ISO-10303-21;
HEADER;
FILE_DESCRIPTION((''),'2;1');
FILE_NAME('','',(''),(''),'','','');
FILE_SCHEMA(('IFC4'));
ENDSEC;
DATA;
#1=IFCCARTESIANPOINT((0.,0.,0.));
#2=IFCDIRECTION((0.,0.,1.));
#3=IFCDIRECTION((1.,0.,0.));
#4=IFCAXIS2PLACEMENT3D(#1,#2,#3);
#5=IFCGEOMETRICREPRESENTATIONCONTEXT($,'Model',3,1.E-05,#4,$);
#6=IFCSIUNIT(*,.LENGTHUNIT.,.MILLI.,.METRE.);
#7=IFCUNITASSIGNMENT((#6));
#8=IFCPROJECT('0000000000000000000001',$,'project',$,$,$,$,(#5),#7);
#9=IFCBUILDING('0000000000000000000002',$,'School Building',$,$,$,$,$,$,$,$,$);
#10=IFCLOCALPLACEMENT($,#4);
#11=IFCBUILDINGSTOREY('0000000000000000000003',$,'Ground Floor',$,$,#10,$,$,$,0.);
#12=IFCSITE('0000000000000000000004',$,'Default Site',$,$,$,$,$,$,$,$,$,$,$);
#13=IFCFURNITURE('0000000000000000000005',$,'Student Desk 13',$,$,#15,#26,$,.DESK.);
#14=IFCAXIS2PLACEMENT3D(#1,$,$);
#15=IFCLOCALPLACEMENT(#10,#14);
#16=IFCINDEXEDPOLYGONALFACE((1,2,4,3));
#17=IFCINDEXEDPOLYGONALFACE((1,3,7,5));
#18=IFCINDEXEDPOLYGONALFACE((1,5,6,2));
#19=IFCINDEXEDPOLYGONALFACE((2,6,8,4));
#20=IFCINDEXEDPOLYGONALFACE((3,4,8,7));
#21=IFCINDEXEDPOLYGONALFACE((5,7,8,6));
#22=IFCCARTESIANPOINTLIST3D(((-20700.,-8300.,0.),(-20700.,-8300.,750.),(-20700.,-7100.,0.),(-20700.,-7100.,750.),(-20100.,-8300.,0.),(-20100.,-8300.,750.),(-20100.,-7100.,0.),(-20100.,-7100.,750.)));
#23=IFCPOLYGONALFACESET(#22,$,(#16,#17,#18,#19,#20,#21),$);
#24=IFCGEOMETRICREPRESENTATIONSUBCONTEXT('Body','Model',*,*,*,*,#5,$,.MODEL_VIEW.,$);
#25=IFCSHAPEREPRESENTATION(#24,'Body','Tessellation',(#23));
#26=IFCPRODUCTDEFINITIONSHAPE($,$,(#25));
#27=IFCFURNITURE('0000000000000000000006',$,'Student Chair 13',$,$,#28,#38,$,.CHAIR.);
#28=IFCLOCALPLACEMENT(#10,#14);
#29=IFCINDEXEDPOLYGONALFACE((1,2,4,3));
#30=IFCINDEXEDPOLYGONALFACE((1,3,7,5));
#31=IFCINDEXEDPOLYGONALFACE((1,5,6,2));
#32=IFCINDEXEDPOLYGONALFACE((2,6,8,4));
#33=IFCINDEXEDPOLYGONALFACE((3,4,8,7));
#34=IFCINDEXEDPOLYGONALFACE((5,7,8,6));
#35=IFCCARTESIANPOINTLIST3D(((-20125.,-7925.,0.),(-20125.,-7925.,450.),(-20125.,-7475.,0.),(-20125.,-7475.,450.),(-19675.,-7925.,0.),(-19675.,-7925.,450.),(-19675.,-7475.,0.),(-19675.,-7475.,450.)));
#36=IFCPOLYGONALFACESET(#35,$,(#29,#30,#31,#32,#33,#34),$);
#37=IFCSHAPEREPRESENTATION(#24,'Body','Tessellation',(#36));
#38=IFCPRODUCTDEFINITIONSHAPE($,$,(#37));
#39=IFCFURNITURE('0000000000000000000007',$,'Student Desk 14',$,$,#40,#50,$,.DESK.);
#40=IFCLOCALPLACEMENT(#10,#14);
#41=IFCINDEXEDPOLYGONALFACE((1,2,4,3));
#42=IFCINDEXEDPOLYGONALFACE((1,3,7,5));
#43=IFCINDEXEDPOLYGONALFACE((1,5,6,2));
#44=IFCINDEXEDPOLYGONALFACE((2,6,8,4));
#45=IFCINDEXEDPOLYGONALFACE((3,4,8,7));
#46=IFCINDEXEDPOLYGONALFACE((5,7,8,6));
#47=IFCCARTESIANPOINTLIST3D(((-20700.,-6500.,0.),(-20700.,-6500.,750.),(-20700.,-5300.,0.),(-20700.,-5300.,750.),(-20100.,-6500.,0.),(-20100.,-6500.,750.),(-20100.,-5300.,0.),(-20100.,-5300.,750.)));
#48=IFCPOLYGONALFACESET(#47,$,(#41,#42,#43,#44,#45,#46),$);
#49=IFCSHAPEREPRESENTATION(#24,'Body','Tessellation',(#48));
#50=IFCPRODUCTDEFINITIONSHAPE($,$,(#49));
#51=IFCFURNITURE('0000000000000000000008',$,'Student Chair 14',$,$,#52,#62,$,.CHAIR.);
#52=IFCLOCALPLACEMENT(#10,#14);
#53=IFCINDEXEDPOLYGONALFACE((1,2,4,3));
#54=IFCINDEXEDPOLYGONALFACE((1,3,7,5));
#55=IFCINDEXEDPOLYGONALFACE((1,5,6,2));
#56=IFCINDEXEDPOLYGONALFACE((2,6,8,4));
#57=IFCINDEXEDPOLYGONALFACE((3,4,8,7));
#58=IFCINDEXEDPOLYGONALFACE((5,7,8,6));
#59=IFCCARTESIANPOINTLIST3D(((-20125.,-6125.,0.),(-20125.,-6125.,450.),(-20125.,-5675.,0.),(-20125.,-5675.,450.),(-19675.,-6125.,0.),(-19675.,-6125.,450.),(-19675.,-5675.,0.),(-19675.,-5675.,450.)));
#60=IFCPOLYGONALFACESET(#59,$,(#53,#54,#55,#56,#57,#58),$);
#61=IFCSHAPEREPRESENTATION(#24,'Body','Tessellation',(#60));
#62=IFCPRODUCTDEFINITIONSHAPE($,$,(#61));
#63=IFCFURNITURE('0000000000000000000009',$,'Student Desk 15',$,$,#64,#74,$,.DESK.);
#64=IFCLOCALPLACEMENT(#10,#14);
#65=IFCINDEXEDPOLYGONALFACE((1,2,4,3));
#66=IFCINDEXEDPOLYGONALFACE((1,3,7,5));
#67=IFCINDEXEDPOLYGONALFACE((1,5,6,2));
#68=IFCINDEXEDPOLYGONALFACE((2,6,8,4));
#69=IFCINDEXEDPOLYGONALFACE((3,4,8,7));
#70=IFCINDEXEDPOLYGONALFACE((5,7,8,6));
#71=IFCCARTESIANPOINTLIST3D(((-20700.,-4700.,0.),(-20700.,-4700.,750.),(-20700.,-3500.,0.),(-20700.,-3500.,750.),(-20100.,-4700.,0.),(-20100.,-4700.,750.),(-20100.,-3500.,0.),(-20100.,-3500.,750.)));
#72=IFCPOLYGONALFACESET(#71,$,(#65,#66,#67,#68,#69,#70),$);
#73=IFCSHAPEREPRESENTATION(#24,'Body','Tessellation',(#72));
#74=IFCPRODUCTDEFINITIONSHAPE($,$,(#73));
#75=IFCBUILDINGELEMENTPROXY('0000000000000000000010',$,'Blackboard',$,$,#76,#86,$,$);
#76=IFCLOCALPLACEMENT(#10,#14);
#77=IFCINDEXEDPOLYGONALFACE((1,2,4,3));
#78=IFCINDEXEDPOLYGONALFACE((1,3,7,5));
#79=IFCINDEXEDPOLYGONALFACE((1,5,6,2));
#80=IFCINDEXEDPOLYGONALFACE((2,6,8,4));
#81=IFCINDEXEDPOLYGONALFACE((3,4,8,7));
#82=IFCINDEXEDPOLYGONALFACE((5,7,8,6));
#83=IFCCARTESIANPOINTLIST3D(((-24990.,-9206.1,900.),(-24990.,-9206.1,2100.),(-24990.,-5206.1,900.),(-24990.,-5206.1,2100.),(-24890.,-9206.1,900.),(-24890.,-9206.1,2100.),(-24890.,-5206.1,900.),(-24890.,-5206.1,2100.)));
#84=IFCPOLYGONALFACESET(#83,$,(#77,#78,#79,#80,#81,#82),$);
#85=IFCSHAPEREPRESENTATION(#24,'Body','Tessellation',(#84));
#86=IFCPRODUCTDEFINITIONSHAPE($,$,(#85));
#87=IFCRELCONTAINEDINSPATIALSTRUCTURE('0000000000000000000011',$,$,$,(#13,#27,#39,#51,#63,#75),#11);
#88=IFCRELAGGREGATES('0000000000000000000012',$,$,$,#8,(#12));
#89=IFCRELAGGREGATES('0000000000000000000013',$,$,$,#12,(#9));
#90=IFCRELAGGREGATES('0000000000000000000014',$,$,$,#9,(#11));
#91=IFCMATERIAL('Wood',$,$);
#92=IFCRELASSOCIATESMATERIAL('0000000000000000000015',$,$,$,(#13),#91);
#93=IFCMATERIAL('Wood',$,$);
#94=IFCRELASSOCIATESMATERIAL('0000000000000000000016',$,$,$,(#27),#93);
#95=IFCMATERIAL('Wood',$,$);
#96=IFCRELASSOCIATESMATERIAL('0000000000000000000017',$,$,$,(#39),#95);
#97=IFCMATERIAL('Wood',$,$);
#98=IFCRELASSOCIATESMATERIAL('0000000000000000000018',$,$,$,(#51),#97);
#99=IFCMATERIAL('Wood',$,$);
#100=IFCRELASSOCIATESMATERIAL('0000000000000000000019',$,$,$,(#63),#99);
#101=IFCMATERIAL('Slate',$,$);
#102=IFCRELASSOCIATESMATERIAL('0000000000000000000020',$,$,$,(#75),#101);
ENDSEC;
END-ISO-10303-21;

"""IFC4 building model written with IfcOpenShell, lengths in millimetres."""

from ifc_helpers import new_model, si_unit, frame, origin_with_axes, origin_2d, place, context, subcontext, project, spatial, rectangle, extrude, material, element, save


model = new_model("IFC4")

# Units and contexts
model_context = context("Model", 3, precision=1e-05, world=origin_with_axes())
body_context = subcontext(model_context, "Body", "Model", "MODEL_VIEW")
ifc_project = project(units=[si_unit("LENGTHUNIT", "METRE", prefix="MILLI")], contexts=[model_context])

# Site, building, storey
site = spatial("IfcSite", under=ifc_project, Name="Default Site")
building = spatial("IfcBuilding", under=site, Name="School Building")
storey_placement = place(None, origin_with_axes())
storey = spatial("IfcBuildingStorey", under=building, at=storey_placement, Name="Ground Floor", Elevation=0.0)

# Furniture
ifc_material_1 = material(Name="Wood")
furniture_1_placement = place(storey_placement, frame((-20400.0, -7700.0, 0.0), z_axis=(0.0, 0.0, 1.0), x_axis=(0.0, 1.0, 0.0)))
element("IfcFurniture", 1, at=furniture_1_placement, inside=storey, material=ifc_material_1, Name="Student Desk 13", PredefinedType="DESK", context=body_context, shape_type="SweptSolid", body=[
    extrude(rectangle(XDim=1200.0, YDim=600.0, at=origin_2d()), origin_with_axes(), (0.0, 0.0, 1.0), 750.0),
])
ifc_material_2 = material(Name="Wood")
furniture_2_placement = place(storey_placement, frame((-19900.0, -7700.0, 0.0), z_axis=(0.0, 0.0, 1.0), x_axis=(1.0, 0.0, 0.0)))
element("IfcFurniture", 2, at=furniture_2_placement, inside=storey, material=ifc_material_2, Name="Student Chair 13", PredefinedType="CHAIR", context=body_context, shape_type="SweptSolid", body=[
    extrude(rectangle(XDim=450.0, YDim=450.0, at=origin_2d()), origin_with_axes(), (0.0, 0.0, 1.0), 450.0),
])
ifc_material_3 = material(Name="Wood")
furniture_3_placement = place(storey_placement, frame((-20400.0, -5900.0, 0.0), z_axis=(0.0, 0.0, 1.0), x_axis=(0.0, 1.0, 0.0)))
element("IfcFurniture", 3, at=furniture_3_placement, inside=storey, material=ifc_material_3, Name="Student Desk 14", PredefinedType="DESK", context=body_context, shape_type="SweptSolid", body=[
    extrude(rectangle(XDim=1200.0, YDim=600.0, at=origin_2d()), origin_with_axes(), (0.0, 0.0, 1.0), 750.0),
])
ifc_material_4 = material(Name="Wood")
furniture_4_placement = place(storey_placement, frame((-19900.0, -5900.0, 0.0), z_axis=(0.0, 0.0, 1.0), x_axis=(1.0, 0.0, 0.0)))
element("IfcFurniture", 4, at=furniture_4_placement, inside=storey, material=ifc_material_4, Name="Student Chair 14", PredefinedType="CHAIR", context=body_context, shape_type="SweptSolid", body=[
    extrude(rectangle(XDim=450.0, YDim=450.0, at=origin_2d()), origin_with_axes(), (0.0, 0.0, 1.0), 450.0),
])
ifc_material_5 = material(Name="Wood")
furniture_5_placement = place(storey_placement, frame((-20400.0, -4100.0, 0.0), z_axis=(0.0, 0.0, 1.0), x_axis=(0.0, 1.0, 0.0)))
element("IfcFurniture", 5, at=furniture_5_placement, inside=storey, material=ifc_material_5, Name="Student Desk 15", PredefinedType="DESK", context=body_context, shape_type="SweptSolid", body=[
    extrude(rectangle(XDim=1200.0, YDim=600.0, at=origin_2d()), origin_with_axes(), (0.0, 0.0, 1.0), 750.0),
])

# Building element proxy
ifc_material_6 = material(Name="Slate")
proxy_placement = place(storey_placement, frame((-24940.0, -7206.1, 900.0), z_axis=(0.0, 0.0, 1.0), x_axis=(1.0, 0.0, 0.0)))
element("IfcBuildingElementProxy", 6, at=proxy_placement, inside=storey, material=ifc_material_6, Name="Blackboard", context=body_context, shape_type="SweptSolid", body=[
    extrude(rectangle(XDim=100.0, YDim=4000.0, at=origin_2d()), origin_with_axes(), (0.0, 0.0, 1.0), 1200.0),
])

save(model, "model.ifc")
